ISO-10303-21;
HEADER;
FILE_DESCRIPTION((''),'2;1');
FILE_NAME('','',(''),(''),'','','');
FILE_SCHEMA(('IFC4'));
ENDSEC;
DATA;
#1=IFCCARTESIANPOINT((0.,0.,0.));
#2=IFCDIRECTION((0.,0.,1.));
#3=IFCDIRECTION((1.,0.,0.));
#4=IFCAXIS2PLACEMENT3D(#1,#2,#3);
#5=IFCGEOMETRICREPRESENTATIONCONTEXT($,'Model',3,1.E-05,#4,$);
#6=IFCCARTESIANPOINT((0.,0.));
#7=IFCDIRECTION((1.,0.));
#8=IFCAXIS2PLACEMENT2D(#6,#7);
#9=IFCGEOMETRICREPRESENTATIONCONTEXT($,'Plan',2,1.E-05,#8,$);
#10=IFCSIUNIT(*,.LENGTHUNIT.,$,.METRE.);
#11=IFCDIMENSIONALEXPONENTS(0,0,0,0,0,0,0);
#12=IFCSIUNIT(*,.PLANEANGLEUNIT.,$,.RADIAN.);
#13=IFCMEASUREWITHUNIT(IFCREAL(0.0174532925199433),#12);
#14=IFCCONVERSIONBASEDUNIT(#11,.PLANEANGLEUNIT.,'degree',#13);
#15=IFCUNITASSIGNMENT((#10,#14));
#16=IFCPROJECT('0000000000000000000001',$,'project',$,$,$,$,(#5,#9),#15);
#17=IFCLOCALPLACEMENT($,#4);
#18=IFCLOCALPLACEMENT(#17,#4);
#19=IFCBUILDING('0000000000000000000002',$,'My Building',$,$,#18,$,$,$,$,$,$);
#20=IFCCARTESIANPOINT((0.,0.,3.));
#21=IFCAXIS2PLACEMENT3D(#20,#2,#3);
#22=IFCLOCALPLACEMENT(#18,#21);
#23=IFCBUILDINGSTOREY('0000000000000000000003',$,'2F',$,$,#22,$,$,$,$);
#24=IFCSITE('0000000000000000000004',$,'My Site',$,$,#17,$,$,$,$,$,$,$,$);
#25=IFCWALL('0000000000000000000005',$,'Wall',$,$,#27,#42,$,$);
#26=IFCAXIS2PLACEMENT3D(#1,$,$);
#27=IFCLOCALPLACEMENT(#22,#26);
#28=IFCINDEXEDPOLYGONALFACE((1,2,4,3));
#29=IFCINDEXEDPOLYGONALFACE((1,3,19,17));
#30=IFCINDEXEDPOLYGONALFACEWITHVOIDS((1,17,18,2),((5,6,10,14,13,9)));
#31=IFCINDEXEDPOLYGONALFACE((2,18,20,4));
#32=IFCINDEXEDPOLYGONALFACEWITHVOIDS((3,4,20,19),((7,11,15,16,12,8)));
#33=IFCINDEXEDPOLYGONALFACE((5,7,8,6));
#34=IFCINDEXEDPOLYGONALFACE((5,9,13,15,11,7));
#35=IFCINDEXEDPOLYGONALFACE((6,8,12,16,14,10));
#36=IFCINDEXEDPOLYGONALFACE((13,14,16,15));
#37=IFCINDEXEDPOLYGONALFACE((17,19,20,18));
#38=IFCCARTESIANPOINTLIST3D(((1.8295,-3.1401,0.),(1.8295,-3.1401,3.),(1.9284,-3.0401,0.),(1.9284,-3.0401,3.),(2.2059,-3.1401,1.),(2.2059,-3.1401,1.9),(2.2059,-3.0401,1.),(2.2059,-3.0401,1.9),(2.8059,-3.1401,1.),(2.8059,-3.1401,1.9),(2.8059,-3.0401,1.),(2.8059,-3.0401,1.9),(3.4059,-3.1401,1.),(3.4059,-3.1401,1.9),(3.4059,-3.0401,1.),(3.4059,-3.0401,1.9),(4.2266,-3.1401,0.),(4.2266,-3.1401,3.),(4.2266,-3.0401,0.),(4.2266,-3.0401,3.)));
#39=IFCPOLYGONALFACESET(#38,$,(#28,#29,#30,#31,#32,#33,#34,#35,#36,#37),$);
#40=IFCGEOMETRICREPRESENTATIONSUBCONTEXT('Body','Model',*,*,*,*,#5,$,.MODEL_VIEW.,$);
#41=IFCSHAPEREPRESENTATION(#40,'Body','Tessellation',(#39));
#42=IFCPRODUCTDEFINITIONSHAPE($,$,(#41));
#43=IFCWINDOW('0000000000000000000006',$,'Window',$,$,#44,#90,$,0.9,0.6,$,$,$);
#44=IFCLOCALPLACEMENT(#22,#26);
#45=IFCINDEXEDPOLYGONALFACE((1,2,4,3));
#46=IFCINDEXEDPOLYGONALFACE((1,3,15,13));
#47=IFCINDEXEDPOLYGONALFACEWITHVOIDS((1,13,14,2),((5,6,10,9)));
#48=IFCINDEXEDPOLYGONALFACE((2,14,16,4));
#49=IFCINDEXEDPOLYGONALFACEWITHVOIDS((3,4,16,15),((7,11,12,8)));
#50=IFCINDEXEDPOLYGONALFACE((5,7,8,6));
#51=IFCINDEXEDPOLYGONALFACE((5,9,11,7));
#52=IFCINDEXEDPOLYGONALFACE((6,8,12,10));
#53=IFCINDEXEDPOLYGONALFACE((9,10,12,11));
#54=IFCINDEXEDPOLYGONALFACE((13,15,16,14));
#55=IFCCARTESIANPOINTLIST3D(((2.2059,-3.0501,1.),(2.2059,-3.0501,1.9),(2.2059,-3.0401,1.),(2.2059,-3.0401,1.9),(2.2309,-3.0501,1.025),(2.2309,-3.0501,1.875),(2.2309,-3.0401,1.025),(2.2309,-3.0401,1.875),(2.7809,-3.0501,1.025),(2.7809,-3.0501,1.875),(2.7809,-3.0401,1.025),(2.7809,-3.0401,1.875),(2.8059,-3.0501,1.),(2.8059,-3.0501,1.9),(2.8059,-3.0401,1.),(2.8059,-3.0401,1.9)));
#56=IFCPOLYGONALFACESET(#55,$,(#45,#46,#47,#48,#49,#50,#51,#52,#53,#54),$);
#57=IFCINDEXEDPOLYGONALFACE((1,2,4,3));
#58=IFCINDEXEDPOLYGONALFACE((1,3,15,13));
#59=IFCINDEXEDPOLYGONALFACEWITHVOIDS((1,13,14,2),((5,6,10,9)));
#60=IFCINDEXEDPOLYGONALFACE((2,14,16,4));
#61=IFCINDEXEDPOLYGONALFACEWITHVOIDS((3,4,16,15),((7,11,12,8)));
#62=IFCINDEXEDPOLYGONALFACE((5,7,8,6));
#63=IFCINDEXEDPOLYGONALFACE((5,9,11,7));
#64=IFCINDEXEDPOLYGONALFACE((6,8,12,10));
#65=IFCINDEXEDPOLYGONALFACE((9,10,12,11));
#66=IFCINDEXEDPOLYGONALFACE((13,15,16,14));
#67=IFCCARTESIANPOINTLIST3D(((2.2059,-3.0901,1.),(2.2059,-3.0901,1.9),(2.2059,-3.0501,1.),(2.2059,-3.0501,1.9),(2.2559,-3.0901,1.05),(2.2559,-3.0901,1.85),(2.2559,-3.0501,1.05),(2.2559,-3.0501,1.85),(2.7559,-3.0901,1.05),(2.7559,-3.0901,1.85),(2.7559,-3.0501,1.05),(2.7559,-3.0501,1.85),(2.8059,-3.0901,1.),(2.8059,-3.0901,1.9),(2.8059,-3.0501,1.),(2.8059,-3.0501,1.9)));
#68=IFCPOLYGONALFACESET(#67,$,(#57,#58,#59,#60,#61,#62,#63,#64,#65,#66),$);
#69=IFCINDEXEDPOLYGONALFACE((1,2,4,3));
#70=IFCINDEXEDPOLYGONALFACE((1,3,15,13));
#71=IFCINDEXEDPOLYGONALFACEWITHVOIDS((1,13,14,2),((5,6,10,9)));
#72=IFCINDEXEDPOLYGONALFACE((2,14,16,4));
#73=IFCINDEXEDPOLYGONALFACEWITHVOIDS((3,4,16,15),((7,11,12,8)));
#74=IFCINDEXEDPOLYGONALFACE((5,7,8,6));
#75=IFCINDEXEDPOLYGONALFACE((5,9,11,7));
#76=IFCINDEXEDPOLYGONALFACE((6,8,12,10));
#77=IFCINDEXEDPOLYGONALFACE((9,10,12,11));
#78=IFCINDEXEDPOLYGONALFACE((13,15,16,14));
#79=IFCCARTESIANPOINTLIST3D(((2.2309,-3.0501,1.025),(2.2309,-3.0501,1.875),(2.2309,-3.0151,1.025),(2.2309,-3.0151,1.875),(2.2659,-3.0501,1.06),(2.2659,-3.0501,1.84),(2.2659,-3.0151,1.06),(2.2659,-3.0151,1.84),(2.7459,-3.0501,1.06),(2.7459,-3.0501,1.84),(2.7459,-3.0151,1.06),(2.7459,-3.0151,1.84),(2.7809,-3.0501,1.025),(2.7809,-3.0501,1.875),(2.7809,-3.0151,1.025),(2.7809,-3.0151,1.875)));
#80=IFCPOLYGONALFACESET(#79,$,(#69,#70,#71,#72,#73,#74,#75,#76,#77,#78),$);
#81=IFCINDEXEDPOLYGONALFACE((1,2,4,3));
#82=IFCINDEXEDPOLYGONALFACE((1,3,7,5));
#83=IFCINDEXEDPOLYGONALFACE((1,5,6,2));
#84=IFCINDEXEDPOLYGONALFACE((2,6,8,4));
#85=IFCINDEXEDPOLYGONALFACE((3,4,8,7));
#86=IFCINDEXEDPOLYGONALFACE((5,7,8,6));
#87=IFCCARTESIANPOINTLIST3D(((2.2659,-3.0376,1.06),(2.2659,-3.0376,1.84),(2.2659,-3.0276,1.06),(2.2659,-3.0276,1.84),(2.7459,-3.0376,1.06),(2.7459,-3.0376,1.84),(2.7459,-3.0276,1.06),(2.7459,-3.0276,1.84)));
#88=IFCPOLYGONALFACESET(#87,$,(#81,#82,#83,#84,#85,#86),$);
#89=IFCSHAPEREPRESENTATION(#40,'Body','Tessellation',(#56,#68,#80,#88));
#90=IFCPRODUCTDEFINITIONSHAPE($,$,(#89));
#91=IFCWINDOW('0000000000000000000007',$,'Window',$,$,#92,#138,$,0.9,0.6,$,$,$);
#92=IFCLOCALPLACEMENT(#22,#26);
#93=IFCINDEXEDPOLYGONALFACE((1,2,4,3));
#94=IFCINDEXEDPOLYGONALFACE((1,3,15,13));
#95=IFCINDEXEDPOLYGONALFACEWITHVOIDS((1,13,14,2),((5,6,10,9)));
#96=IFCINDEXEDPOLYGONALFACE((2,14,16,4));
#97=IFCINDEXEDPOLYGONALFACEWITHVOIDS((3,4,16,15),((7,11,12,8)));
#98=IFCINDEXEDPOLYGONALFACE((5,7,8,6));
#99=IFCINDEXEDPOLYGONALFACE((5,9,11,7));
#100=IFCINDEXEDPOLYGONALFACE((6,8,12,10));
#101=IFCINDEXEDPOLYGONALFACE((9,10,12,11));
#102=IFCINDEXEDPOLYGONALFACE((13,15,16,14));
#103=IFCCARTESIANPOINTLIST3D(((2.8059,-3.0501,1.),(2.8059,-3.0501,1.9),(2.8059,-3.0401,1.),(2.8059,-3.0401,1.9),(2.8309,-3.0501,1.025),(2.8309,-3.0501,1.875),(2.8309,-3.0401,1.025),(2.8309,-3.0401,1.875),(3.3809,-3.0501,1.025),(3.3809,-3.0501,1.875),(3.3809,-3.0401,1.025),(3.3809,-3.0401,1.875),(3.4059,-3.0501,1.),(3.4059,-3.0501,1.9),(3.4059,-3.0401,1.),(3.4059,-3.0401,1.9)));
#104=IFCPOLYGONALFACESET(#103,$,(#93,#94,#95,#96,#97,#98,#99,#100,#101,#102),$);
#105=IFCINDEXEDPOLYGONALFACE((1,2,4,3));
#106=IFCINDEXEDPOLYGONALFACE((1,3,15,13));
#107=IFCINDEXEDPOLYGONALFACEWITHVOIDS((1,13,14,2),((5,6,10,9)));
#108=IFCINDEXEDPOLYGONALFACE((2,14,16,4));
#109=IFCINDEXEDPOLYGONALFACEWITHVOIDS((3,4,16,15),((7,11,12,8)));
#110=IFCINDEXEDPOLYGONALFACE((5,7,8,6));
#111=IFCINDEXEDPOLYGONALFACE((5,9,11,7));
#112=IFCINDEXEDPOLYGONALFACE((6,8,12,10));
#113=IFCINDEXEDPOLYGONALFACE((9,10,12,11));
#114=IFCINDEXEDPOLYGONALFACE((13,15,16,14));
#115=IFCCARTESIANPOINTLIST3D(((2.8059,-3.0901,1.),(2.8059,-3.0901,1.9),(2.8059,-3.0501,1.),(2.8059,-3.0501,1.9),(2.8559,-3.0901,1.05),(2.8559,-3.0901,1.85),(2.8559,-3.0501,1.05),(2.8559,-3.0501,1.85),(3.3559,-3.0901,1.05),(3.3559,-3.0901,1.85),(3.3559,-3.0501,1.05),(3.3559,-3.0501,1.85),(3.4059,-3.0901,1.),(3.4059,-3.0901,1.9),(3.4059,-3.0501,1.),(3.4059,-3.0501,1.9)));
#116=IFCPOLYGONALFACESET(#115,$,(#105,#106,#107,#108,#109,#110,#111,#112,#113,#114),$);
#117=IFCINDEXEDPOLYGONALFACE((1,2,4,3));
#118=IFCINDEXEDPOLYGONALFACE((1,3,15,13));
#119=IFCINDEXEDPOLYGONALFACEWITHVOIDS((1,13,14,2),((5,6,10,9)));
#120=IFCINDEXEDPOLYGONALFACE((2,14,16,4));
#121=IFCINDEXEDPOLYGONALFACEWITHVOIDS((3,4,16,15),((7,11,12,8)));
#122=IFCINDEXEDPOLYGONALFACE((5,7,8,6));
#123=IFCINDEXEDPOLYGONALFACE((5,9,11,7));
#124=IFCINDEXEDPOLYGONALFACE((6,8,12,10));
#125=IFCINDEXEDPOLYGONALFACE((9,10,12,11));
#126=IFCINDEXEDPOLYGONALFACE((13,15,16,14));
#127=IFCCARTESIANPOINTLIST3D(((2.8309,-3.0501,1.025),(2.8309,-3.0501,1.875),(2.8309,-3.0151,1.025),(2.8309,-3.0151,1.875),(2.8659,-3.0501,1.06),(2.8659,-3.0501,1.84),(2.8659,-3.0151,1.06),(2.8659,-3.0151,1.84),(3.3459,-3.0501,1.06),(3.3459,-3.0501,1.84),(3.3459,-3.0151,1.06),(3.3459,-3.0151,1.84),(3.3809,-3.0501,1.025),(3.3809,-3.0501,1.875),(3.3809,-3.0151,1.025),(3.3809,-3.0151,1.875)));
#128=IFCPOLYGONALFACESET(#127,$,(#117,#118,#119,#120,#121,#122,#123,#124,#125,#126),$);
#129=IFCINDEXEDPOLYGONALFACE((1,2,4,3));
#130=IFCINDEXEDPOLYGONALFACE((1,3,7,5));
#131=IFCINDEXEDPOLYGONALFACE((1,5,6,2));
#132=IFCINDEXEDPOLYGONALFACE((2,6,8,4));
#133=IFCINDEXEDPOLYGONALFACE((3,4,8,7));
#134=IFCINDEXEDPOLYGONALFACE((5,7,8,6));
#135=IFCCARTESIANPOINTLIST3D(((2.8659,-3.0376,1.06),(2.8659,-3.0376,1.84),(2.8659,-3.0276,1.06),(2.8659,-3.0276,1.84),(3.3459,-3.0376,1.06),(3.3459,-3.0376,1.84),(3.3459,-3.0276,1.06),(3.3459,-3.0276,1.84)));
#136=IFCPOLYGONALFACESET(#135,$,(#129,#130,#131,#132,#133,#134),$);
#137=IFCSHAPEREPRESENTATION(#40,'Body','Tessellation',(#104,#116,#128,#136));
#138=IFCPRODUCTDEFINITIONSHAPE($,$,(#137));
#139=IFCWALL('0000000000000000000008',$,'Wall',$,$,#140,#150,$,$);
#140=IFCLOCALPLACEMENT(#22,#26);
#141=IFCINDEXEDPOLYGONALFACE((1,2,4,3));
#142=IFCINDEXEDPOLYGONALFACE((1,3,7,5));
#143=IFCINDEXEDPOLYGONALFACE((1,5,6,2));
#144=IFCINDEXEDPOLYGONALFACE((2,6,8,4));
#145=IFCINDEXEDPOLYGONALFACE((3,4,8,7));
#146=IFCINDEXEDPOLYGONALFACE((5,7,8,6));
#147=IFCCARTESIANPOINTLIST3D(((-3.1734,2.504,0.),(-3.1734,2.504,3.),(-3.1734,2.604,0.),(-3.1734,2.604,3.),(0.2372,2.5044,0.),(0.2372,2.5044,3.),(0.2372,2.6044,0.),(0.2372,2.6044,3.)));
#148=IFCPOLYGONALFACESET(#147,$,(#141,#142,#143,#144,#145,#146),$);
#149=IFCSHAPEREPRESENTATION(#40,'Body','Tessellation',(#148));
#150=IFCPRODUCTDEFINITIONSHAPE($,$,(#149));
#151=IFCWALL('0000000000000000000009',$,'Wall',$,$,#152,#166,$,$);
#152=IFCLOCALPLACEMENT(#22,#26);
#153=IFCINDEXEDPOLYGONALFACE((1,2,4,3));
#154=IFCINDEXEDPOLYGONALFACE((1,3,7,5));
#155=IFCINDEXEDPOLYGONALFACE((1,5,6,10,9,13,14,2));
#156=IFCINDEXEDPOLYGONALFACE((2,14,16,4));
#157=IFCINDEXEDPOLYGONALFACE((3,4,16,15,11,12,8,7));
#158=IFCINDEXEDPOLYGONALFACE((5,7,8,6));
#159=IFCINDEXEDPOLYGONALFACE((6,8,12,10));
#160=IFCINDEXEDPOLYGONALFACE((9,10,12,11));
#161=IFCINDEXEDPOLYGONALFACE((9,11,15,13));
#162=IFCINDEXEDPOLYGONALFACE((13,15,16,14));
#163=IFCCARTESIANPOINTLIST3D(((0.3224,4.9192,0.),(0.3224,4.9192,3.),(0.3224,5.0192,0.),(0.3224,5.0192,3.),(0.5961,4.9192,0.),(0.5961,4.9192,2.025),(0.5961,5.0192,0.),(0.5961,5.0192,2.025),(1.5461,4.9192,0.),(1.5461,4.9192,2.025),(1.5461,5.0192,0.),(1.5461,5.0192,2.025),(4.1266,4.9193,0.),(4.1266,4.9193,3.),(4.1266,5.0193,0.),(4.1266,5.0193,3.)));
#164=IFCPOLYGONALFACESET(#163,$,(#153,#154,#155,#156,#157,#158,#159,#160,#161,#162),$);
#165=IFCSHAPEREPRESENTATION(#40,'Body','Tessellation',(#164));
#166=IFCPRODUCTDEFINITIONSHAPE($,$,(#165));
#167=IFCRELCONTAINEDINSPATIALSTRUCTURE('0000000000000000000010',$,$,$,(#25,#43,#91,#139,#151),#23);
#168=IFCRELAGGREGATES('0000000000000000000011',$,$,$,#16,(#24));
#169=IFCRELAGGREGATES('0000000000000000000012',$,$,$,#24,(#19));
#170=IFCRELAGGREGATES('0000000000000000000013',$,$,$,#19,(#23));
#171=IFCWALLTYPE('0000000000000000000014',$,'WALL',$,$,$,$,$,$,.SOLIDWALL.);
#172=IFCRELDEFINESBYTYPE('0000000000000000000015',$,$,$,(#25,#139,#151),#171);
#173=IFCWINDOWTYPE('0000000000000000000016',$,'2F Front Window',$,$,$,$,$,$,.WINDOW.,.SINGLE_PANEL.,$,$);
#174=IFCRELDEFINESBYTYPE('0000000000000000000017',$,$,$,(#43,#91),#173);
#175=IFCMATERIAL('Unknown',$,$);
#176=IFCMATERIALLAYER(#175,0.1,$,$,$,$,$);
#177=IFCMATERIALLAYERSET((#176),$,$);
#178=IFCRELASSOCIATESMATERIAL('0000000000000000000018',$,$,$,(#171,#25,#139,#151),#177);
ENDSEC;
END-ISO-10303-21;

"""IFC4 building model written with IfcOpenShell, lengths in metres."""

from ifc_helpers import new_model, entity, si_unit, converted_unit, frame, origin_with_axes, origin_2d_with_axis, place, context, subcontext, project, spatial, line, indexed_curve, outline, extrude, shape, source, transform, mapped, material, layer, layer_set, layer_usage, type_object, type_shapes, element, fill, save


model = new_model("IFC4")

# Units and contexts
model_context = context("Model", 3, precision=1e-05, world=origin_with_axes())
plan_context = context("Plan", 2, precision=1e-05, world=origin_2d_with_axis())
body_context_1 = subcontext(model_context, "Body", "Model", "MODEL_VIEW")
body_context_2 = subcontext(plan_context, "Body", "Plan", "PLAN_VIEW")
ifc_project = project(units=[si_unit("LENGTHUNIT", "METRE"), converted_unit("PLANEANGLEUNIT", "degree", entity("IfcReal", 0.0174532925199433), si_unit("PLANEANGLEUNIT", "RADIAN"), dimensions=[0, 0, 0, 0, 0, 0, 0])], contexts=[model_context, plan_context])

# Site, building, storey
site_placement = place(None, origin_with_axes())
site = spatial("IfcSite", under=ifc_project, at=site_placement, Name="My Site")
building_placement = place(site_placement, origin_with_axes())
building = spatial("IfcBuilding", under=site, at=building_placement, Name="My Building")
storey_placement = place(building_placement, frame((0.0, 0.0, 3.0), z_axis=(0.0, 0.0, 1.0), x_axis=(1.0, 0.0, 0.0)))
storey = spatial("IfcBuildingStorey", under=building, at=storey_placement, Name="2F")

# Shared definitions
ifc_material = material(Name="Unknown")

# Shared definitions
ifc_layer_1 = layer(ifc_material, 0.1)
ifc_layer_set_1 = layer_set([ifc_layer_1])
wall_type = type_object("IfcWallType", Name="WALL", PredefinedType="SOLIDWALL", material=ifc_layer_set_1)

# Wall, openings, windows
ifc_layer_usage_1 = layer_usage(ifc_layer_set_1, "AXIS2", "POSITIVE", 0.0)
wall_1_placement = place(storey_placement, frame((1.8295, -3.1401, 0.0), z_axis=(0.0, 0.0, 1.0), x_axis=(1.0, 0.0, 0.0)))
wall_1 = element("IfcWall", 1, at=wall_1_placement, inside=storey, type_object=wall_type, material=ifc_layer_usage_1, Name="Wall", context=body_context_1, shape_type="SweptSolid", body=[
    extrude(outline(indexed_curve([(0.0, 0.0), (0.0989, 0.1), (2.3971, 0.1), (2.3971, 0.0)], segments=[line(1, 2, 3, 4, 1)])), origin_with_axes(), (0.0, 0.0, 1.0), 3.0),
])
shared_shape_1 = source(origin_with_axes(), body_context_1, "Body", "SweptSolid", [
    extrude(outline(indexed_curve([(0.0, 0.0), (0.6, 0.0), (0.6, 0.9), (0.0, 0.9)], segments=[line(1, 2, 3, 4, 1)])), frame((0.0, -0.6, 0.0), z_axis=(0.0, -1.0, 0.0), x_axis=(1.0, 0.0, 0.0)), (0.0, 0.0, -1.0), 1.2),
])
opening_1_placement = place(wall_1_placement, frame((0.3764, 0.0, 1.0), z_axis=(0.0, 0.0, 1.0), x_axis=(1.0, 0.0, 0.0)))
opening_1 = element("IfcOpeningElement", 2, at=opening_1_placement, cuts=wall_1, PredefinedType="OPENING", context=body_context_1, shape_type="MappedRepresentation", body=[
    mapped(shared_shape_1, transform((0.0, 0.0, 0.0), x_axis=(1.0, 0.0, 0.0), y_axis=(0.0, 1.0, 0.0), z_axis=(0.0, 0.0, 1.0), scale=1.0)),
])
opening_2_placement = place(wall_1_placement, frame((0.9764, 0.0, 1.0), z_axis=(0.0, 0.0, 1.0), x_axis=(1.0, 0.0, 0.0)))
opening_2 = element("IfcOpeningElement", 3, at=opening_2_placement, cuts=wall_1, PredefinedType="OPENING", context=body_context_1, shape_type="MappedRepresentation", body=[
    mapped(shared_shape_1, transform((0.0, 0.0, 0.0), x_axis=(1.0, 0.0, 0.0), y_axis=(0.0, 1.0, 0.0), z_axis=(0.0, 0.0, 1.0), scale=1.0)),
])
window_type_1 = type_object("IfcWindowType", Name="2F Front Window", PartitioningType="SINGLE_PANEL", PredefinedType="WINDOW")
shared_shape_2 = source(origin_with_axes(), body_context_1, "Body", "SweptSolid", [
    extrude(outline(indexed_curve([(0.0, 0.0), (0.6, 0.0), (0.6, 0.9), (0.0, 0.9)], segments=[line(1, 2, 3, 4, 1)]), holes=[indexed_curve([(0.025, 0.025), (0.575, 0.025), (0.575, 0.875), (0.025, 0.875)], segments=[line(1, 2, 3, 4, 1)])]), frame((0.0, 0.09, 0.0), z_axis=(0.0, -1.0, 0.0), x_axis=(1.0, 0.0, 0.0)), (0.0, 0.0, -1.0), 0.01),
    extrude(outline(indexed_curve([(0.0, 0.0), (0.6, 0.0), (0.6, 0.9), (0.0, 0.9)], segments=[line(1, 2, 3, 4, 1)]), holes=[indexed_curve([(0.05, 0.05), (0.55, 0.05), (0.55, 0.85), (0.05, 0.85)], segments=[line(1, 2, 3, 4, 1)])]), frame((0.0, 0.05, 0.0), z_axis=(0.0, -1.0, 0.0), x_axis=(1.0, 0.0, 0.0)), (0.0, 0.0, -1.0), 0.04),
    extrude(outline(indexed_curve([(0.0, 0.0), (0.55, 0.0), (0.55, 0.85), (0.0, 0.85)], segments=[line(1, 2, 3, 4, 1)]), holes=[indexed_curve([(0.035, 0.035), (0.515, 0.035), (0.515, 0.815), (0.035, 0.815)], segments=[line(1, 2, 3, 4, 1)])]), frame((0.025, 0.09, 0.025), z_axis=(0.0, -1.0, 0.0), x_axis=(1.0, 0.0, 0.0)), (0.0, 0.0, -1.0), 0.035),
    extrude(outline(indexed_curve([(0.035, 0.035), (0.515, 0.035), (0.515, 0.815), (0.035, 0.815)], segments=[line(1, 2, 3, 4, 1)])), frame((0.025, 0.1025, 0.025), z_axis=(0.0, -1.0, 0.0), x_axis=(1.0, 0.0, 0.0)), (0.0, 0.0, -1.0), 0.01),
])
shared_shape_3 = source(origin_with_axes(), body_context_2, "Body", "Curve2D", [
    entity("IfcIndexedPolyCurve", entity("IfcCartesianPointList2D", [[0.05, 0.05], [0.55, 0.05]])),
    entity("IfcIndexedPolyCurve", entity("IfcCartesianPointList2D", [[0.0, 0.1], [0.025, 0.1], [0.025, 0.09], [0.05, 0.09], [0.05, 0.05], [0.0, 0.05]]), [entity("IfcLineIndex", [1, 2, 3, 4, 5, 6, 1])]),
    entity("IfcIndexedPolyCurve", entity("IfcCartesianPointList2D", [[0.6, 0.1], [0.575, 0.1], [0.575, 0.09], [0.55, 0.09], [0.55, 0.05], [0.6, 0.05]]), [entity("IfcLineIndex", [1, 2, 3, 4, 5, 6, 1])]),
    entity("IfcIndexedPolyCurve", entity("IfcCartesianPointList2D", [[0.025, 0.09], [0.06, 0.09], [0.06, 0.125], [0.025, 0.125]]), [entity("IfcLineIndex", [1, 2, 3, 4, 1])]),
    entity("IfcIndexedPolyCurve", entity("IfcCartesianPointList2D", [[0.575, 0.09], [0.54, 0.09], [0.54, 0.125], [0.575, 0.125]]), [entity("IfcLineIndex", [1, 2, 3, 4, 1])]),
    entity("IfcIndexedPolyCurve", entity("IfcCartesianPointList2D", [[0.06, 0.09], [0.54, 0.09]])),
    entity("IfcIndexedPolyCurve", entity("IfcCartesianPointList2D", [[0.06, 0.125], [0.54, 0.125]])),
    entity("IfcIndexedPolyCurve", entity("IfcCartesianPointList2D", [[0.06, 0.1075], [0.54, 0.1075]])),
])
type_shapes(window_type_1, [shared_shape_2, shared_shape_3])
window_1_placement = place(opening_1_placement, frame((0.0, 0.0, 0.0), z_axis=(0.0, 0.0, 1.0), x_axis=(1.0, 0.0, 0.0)))
window_1 = element("IfcWindow", 4, at=window_1_placement, inside=storey, type_object=window_type_1, Name="Window", OverallHeight=0.9, OverallWidth=0.6, shapes=[
    shape(body_context_1, "Body", "MappedRepresentation", [mapped(shared_shape_2, transform((0.0, 0.0, 0.0), x_axis=(1.0, 0.0, 0.0), y_axis=(0.0, 1.0, 0.0), z_axis=(0.0, 0.0, 1.0), scale=1.0))]),
    shape(body_context_2, "Body", "MappedRepresentation", [mapped(shared_shape_3, transform((0.0, 0.0, 0.0), x_axis=(1.0, 0.0, 0.0), y_axis=(0.0, 1.0, 0.0), z_axis=(0.0, 0.0, 1.0), scale=1.0))]),
])
fill(opening_1, window_1)
window_2_placement = place(opening_2_placement, frame((0.0, 0.0, 0.0), z_axis=(0.0, 0.0, 1.0), x_axis=(1.0, 0.0, 0.0)))
window_2 = element("IfcWindow", 5, at=window_2_placement, inside=storey, type_object=window_type_1, Name="Window", OverallHeight=0.9, OverallWidth=0.6, shapes=[
    shape(body_context_1, "Body", "MappedRepresentation", [mapped(shared_shape_2, transform((0.0, 0.0, 0.0), x_axis=(1.0, 0.0, 0.0), y_axis=(0.0, 1.0, 0.0), z_axis=(0.0, 0.0, 1.0), scale=1.0))]),
    shape(body_context_2, "Body", "MappedRepresentation", [mapped(shared_shape_3, transform((0.0, 0.0, 0.0), x_axis=(1.0, 0.0, 0.0), y_axis=(0.0, 1.0, 0.0), z_axis=(0.0, 0.0, 1.0), scale=1.0))]),
])
fill(opening_2, window_2)

# Wall
ifc_layer_usage_2 = layer_usage(ifc_layer_set_1, "AXIS2", "POSITIVE", 0.0)
wall_2_placement = place(storey_placement, frame((-3.1734, 2.504, 0.0), z_axis=(0.0, 0.0, 1.0), x_axis=(1.0, 0.000117, 0.0)))
element("IfcWall", 6, at=wall_2_placement, inside=storey, type_object=wall_type, material=ifc_layer_usage_2, Name="Wall", context=body_context_1, shape_type="SweptSolid", body=[
    extrude(outline(indexed_curve([(0.0, 0.0), (0.0, 0.1), (3.4106, 0.1), (3.4106, 0.0)], segments=[line(1, 2, 3, 4, 1)])), origin_with_axes(), (0.0, 0.0, 1.0), 3.0),
])

# Wall, opening
ifc_layer_usage_3 = layer_usage(ifc_layer_set_1, "AXIS2", "POSITIVE", 0.0)
wall_3_placement = place(storey_placement, frame((4.1266, 5.0193, 0.0), z_axis=(0.0, 0.0, 1.0), x_axis=(-1.0, -0.000042, 0.0)))
wall_3 = element("IfcWall", 7, at=wall_3_placement, inside=storey, type_object=wall_type, material=ifc_layer_usage_3, Name="Wall", context=body_context_1, shape_type="SweptSolid", body=[
    extrude(outline(indexed_curve([(0.0, 0.0), (0.0, 0.1), (3.8042, 0.1), (3.8042, 0.0)], segments=[line(1, 2, 3, 4, 1)])), origin_with_axes(), (0.0, 0.0, 1.0), 3.0),
])
shared_shape_4 = source(origin_with_axes(), body_context_1, "Body", "SweptSolid", [
    extrude(outline(indexed_curve([(0.0, 0.0), (0.95, 0.0), (0.95, 2.025), (0.0, 2.025)], segments=[line(1, 2, 3, 4, 1)])), frame((-0.025, -0.6, 0.0), z_axis=(0.0, -1.0, 0.0), x_axis=(1.0, 0.0, 0.0)), (0.0, 0.0, -1.0), 1.2),
])
opening_3_placement = place(wall_3_placement, frame((2.6055, 0.0, 0.0), z_axis=(0.0, 0.0, 1.0), x_axis=(1.0, 0.0, 0.0)))
element("IfcOpeningElement", 8, at=opening_3_placement, cuts=wall_3, PredefinedType="OPENING", context=body_context_1, shape_type="MappedRepresentation", body=[
    mapped(shared_shape_4, transform((0.0, 0.0, 0.0), x_axis=(1.0, 0.0, 0.0), y_axis=(0.0, 1.0, 0.0), z_axis=(0.0, 0.0, 1.0), scale=1.0)),
])

save(model, "model.ifc")
